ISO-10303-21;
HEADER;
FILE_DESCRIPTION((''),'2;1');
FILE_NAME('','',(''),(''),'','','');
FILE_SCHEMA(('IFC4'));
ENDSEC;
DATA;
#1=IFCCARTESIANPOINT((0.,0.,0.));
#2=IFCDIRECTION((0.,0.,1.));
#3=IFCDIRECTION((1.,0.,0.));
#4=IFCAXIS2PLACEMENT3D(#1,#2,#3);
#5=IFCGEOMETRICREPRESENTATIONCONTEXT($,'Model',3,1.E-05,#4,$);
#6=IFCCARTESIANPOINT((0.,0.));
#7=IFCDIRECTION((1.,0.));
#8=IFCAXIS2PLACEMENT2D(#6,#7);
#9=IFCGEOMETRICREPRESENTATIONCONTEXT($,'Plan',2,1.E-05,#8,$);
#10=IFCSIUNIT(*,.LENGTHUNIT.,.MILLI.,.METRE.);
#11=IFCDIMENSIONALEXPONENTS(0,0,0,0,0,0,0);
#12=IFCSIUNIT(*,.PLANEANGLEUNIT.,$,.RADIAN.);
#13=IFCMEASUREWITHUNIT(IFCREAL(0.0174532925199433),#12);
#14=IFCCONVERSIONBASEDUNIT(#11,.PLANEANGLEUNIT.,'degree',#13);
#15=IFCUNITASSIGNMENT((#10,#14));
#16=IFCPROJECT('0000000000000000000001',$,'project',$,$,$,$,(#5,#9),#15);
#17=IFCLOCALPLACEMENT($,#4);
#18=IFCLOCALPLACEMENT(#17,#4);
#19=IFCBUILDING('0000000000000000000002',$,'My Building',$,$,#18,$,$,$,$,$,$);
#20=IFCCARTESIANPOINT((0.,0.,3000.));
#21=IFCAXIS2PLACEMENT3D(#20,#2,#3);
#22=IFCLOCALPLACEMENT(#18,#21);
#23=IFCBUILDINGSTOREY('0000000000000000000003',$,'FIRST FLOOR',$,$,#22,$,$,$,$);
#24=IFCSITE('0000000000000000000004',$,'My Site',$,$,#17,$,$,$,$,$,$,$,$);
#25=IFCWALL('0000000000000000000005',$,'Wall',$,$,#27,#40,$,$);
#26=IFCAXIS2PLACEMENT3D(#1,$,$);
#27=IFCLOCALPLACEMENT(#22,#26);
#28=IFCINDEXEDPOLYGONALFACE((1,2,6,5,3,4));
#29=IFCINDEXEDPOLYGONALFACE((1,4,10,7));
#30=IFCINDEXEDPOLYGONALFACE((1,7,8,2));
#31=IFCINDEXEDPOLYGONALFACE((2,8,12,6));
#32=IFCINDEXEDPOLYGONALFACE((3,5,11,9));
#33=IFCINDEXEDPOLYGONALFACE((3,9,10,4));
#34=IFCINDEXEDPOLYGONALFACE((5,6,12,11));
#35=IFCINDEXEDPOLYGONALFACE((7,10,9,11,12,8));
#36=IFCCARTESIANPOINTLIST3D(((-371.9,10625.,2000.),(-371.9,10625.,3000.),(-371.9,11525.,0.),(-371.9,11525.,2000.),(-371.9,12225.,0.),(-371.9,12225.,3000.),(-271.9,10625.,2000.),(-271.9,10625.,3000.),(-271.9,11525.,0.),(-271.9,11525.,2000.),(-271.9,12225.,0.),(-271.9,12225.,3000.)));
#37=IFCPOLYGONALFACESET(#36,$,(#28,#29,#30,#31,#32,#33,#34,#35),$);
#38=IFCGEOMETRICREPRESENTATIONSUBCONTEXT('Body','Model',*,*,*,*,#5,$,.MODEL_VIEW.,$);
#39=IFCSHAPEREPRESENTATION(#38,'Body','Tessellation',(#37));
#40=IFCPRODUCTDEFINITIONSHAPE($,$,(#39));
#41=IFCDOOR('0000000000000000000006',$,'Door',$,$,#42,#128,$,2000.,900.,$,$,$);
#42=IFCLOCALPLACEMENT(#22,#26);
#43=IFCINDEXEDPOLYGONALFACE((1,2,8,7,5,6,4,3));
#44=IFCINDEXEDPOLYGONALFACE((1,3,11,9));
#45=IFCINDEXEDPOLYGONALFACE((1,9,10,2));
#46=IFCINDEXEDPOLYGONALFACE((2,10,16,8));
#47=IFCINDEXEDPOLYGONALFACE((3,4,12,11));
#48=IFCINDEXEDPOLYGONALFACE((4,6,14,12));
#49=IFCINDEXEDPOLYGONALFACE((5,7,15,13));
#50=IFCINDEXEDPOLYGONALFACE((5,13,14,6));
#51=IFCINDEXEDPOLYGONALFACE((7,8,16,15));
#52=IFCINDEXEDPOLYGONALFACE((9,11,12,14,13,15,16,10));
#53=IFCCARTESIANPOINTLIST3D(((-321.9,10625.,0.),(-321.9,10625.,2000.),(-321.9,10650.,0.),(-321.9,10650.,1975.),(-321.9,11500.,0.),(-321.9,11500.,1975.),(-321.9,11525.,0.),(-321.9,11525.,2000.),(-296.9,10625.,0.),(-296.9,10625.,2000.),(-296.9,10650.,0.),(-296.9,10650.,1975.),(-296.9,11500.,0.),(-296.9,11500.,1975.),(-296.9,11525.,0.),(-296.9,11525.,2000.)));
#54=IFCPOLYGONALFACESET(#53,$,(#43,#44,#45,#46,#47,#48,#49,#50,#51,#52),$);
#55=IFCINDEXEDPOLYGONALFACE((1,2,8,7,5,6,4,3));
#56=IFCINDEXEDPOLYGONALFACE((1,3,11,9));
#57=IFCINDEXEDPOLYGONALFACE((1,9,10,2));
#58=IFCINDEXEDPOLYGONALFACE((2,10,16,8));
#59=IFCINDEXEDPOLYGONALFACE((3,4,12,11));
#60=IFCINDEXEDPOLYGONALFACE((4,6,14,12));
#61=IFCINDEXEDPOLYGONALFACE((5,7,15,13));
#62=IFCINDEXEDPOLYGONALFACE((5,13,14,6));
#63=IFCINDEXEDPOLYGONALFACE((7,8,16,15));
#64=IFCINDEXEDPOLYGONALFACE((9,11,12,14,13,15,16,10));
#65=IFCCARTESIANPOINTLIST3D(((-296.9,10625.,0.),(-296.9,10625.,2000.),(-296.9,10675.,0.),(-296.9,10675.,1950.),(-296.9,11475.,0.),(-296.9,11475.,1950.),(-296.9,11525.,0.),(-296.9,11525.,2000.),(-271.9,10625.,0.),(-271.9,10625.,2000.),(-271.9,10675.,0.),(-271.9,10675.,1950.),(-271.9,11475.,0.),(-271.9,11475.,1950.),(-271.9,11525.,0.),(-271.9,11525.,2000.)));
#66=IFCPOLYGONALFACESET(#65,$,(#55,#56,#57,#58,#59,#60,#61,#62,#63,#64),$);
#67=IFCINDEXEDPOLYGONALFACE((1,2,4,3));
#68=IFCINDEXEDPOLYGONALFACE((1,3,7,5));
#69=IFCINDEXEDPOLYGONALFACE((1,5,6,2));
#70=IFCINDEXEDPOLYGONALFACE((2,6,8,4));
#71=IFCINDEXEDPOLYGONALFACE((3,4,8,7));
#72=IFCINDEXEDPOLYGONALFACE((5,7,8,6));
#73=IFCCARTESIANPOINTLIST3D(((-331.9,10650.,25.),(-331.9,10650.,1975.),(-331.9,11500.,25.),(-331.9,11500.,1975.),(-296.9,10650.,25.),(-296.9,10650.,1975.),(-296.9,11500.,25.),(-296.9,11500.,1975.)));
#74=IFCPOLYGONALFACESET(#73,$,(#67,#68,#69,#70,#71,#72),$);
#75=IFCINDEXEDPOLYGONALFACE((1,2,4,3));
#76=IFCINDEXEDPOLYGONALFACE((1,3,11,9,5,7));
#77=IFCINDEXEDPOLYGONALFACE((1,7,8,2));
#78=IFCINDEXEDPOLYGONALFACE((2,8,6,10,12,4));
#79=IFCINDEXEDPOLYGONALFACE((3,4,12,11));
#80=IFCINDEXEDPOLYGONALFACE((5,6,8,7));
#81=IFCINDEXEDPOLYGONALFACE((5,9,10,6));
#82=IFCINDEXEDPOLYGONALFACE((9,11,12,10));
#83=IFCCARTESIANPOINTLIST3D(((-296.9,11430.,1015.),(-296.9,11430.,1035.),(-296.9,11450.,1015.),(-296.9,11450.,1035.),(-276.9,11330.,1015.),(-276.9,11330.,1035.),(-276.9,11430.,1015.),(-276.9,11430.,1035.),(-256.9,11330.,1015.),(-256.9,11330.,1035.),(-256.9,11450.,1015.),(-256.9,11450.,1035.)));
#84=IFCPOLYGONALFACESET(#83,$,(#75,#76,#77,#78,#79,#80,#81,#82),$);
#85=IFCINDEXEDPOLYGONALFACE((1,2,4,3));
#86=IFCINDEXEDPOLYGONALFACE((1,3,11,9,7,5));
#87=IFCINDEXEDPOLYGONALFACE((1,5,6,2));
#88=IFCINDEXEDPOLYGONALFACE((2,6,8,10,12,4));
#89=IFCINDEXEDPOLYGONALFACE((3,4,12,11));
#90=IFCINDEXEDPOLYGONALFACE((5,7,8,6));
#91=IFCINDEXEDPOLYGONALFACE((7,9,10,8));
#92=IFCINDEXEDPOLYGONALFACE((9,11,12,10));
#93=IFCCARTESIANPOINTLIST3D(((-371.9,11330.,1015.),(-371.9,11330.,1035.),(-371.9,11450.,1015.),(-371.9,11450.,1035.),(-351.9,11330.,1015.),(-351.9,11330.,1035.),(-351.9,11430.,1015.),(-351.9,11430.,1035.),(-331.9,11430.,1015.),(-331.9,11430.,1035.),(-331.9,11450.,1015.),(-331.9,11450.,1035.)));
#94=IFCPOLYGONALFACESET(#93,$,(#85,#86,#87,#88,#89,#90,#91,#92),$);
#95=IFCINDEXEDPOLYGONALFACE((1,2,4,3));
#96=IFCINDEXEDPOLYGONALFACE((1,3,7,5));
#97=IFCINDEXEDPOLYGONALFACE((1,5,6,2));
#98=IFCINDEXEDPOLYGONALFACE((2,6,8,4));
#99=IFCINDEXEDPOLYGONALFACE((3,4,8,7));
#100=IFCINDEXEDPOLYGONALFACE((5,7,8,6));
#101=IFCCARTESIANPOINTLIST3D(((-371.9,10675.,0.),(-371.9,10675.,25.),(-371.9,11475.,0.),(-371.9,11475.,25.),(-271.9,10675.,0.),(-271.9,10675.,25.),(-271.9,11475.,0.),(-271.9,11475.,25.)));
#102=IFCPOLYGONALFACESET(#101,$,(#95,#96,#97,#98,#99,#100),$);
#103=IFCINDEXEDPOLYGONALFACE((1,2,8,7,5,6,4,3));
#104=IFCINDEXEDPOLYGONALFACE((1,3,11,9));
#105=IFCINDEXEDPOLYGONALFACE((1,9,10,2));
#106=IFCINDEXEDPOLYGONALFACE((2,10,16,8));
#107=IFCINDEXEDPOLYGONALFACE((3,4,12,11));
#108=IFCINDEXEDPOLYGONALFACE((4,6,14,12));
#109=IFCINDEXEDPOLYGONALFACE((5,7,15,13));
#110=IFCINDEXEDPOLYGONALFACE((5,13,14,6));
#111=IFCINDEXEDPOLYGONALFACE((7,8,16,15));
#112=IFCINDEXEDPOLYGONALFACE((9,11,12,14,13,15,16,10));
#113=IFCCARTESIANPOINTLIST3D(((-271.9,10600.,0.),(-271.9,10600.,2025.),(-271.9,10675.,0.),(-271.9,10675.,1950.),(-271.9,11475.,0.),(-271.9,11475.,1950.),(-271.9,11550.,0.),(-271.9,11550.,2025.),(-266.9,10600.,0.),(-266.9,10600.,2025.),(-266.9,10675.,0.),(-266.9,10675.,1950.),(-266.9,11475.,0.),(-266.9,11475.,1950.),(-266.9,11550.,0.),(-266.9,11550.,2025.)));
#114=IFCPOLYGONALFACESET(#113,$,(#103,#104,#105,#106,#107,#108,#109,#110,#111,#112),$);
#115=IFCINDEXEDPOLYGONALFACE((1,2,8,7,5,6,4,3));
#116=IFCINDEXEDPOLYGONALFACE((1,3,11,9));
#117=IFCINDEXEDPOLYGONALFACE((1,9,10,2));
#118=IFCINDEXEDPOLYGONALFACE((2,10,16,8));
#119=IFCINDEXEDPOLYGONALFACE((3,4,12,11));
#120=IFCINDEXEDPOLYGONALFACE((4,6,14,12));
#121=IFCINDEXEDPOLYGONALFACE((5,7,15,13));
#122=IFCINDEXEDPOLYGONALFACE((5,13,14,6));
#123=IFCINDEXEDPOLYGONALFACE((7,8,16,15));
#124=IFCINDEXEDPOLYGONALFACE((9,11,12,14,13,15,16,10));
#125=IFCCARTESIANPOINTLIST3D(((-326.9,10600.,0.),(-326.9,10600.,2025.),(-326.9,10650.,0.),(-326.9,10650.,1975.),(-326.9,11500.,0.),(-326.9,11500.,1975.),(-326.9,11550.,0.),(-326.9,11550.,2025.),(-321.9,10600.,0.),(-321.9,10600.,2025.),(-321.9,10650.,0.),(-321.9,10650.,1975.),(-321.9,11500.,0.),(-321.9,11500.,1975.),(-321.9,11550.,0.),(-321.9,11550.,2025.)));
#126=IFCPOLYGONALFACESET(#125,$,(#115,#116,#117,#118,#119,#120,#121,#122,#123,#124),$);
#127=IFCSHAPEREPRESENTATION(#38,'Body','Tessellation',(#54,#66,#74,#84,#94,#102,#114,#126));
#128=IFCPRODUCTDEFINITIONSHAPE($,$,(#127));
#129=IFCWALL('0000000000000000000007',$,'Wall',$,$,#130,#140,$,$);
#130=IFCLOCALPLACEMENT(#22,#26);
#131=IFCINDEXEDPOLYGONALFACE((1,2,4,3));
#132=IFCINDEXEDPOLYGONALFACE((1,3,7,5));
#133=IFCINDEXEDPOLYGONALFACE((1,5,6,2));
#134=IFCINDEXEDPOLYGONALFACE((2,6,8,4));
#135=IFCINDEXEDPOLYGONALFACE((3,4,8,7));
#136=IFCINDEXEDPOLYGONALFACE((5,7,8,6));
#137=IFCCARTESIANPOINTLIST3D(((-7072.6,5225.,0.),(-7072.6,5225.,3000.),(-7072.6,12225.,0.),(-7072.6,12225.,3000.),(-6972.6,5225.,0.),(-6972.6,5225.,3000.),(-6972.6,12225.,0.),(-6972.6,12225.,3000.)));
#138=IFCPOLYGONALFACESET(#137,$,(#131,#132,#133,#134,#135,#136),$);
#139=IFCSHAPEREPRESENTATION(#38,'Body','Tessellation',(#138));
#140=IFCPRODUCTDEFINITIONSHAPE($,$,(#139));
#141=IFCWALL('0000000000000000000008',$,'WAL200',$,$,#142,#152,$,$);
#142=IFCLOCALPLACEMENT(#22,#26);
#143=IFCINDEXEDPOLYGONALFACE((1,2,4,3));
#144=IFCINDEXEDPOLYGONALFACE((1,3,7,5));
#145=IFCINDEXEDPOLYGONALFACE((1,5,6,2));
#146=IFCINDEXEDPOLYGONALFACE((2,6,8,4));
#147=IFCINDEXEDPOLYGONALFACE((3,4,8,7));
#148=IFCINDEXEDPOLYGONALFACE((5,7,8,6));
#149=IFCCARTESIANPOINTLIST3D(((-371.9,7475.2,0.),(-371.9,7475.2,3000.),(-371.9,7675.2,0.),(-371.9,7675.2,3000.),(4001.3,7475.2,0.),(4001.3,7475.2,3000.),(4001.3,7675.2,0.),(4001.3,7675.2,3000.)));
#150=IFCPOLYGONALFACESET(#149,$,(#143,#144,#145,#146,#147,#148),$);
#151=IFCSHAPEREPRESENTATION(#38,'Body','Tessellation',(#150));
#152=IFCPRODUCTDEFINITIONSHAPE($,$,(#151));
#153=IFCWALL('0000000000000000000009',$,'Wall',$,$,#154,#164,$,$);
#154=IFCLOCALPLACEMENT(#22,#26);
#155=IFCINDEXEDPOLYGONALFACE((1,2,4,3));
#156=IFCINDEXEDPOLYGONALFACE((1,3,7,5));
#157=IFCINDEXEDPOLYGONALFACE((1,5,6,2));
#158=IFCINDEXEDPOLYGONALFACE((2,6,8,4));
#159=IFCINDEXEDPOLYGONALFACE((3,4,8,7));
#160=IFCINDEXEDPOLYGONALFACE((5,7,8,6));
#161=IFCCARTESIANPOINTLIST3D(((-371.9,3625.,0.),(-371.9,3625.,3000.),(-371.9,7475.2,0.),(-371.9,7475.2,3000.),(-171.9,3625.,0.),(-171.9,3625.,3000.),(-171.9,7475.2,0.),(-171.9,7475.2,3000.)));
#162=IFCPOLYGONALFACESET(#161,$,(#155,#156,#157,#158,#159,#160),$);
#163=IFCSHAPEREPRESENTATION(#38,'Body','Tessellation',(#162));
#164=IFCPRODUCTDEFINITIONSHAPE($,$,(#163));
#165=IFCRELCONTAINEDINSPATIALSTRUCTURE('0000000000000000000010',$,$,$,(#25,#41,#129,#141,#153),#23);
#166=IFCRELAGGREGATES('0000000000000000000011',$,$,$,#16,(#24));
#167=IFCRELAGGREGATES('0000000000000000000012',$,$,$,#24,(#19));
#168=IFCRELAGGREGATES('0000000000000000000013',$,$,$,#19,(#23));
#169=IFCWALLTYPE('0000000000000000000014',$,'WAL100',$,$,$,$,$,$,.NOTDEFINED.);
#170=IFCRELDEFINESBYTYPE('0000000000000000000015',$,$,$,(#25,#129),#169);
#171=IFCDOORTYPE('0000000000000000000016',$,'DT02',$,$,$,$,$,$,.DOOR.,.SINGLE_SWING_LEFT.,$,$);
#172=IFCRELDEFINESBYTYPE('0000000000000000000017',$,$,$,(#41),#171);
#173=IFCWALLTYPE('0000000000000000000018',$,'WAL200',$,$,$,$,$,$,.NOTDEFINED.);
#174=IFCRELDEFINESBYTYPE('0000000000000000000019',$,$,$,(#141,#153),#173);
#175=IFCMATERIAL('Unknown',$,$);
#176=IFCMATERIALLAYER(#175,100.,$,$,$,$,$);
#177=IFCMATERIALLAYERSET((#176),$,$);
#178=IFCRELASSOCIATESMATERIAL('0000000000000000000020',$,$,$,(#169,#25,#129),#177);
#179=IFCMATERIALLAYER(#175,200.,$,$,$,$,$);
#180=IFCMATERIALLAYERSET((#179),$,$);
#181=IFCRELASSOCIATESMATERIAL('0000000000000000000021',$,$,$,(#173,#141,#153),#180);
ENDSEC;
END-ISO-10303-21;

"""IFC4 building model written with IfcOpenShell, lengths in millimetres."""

from ifc_helpers import new_model, entity, si_unit, converted_unit, frame, origin_with_axes, origin_2d_with_axis, place, context, subcontext, project, spatial, line, indexed_curve, outline, extrude, shape, source, transform, mapped, material, layer, layer_set, layer_usage, type_object, type_shapes, element, fill, save


model = new_model("IFC4")

# Units and contexts
model_context = context("Model", 3, precision=1e-05, world=origin_with_axes())
plan_context = context("Plan", 2, precision=1e-05, world=origin_2d_with_axis())
body_context_1 = subcontext(model_context, "Body", "Model", "MODEL_VIEW")
body_context_2 = subcontext(plan_context, "Body", "Plan", "PLAN_VIEW")
ifc_project = project(units=[si_unit("LENGTHUNIT", "METRE", prefix="MILLI"), converted_unit("PLANEANGLEUNIT", "degree", entity("IfcReal", 0.0174532925199433), si_unit("PLANEANGLEUNIT", "RADIAN"), dimensions=[0, 0, 0, 0, 0, 0, 0])], contexts=[model_context, plan_context])

# Site, building, storey
site_placement = place(None, origin_with_axes())
site = spatial("IfcSite", under=ifc_project, at=site_placement, Name="My Site")
building_placement = place(site_placement, origin_with_axes())
building = spatial("IfcBuilding", under=site, at=building_placement, Name="My Building")
storey_placement = place(building_placement, frame((0.0, 0.0, 3000.0), z_axis=(0.0, 0.0, 1.0), x_axis=(1.0, 0.0, 0.0)))
storey = spatial("IfcBuildingStorey", under=building, at=storey_placement, Name="FIRST FLOOR")

# Shared definitions
ifc_material = material(Name="Unknown")

# Shared definitions
ifc_layer_1 = layer(ifc_material, 100.0)
ifc_layer_set_1 = layer_set([ifc_layer_1])
wall_type_1 = type_object("IfcWallType", Name="WAL100", PredefinedType="NOTDEFINED", material=ifc_layer_set_1)
wall_1_placement = place(storey_placement, frame((-271.9, 7675.2, 0.0), z_axis=(0.0, 0.0, 1.0), x_axis=(0.0, 1.0, 0.0)))

# Wall, opening, door
ifc_layer_usage_1 = layer_usage(ifc_layer_set_1, "AXIS2", "POSITIVE", 0.0)
wall_2_placement = place(storey_placement, frame((-271.9, 10625.0, 0.0), z_axis=(0.0, 0.0, 1.0), x_axis=(0.0, 1.0, 0.0)))
wall_2 = element("IfcWall", 1, at=wall_2_placement, inside=storey, type_object=wall_type_1, material=ifc_layer_usage_1, Name="Wall", context=body_context_1, shape_type="SweptSolid", body=[
    extrude(outline(indexed_curve([(0.0, 0.0), (0.0, 100.0), (1600.0, 100.0), (1600.0, 0.0), (0.0, 0.0)], self_intersect=False)), origin_with_axes(), (0.0, 0.0, 1.0), 3000.0),
])
shared_shape_1 = source(origin_with_axes(), body_context_1, "Body", "SweptSolid", [
    extrude(outline(indexed_curve([(0.0, 0.0), (900.0, 0.0), (900.0, 2000.0), (0.0, 2000.0)], segments=[line(1, 2), line(2, 3), line(3, 4), line(4, 1)])), frame((0.0, -100.0, 0.0), z_axis=(0.0, -1.0, 0.0), x_axis=(1.0, 0.0, 0.0)), (0.0, 0.0, -1.0), 300.0),
])
opening_1_placement = place(wall_2_placement, frame((0.0, 0.0, 0.0), z_axis=(0.0, 0.0, 1.0), x_axis=(1.0, 0.0, 0.0)))
opening_1 = element("IfcOpeningElement", 2, at=opening_1_placement, cuts=wall_2, PredefinedType="OPENING", context=body_context_1, shape_type="MappedRepresentation", body=[
    mapped(shared_shape_1, transform((0.0, 0.0, 0.0), x_axis=(1.0, 0.0, 0.0), y_axis=(0.0, 1.0, 0.0), z_axis=(0.0, 0.0, 1.0), scale=1.0)),
])
door_type = type_object("IfcDoorType", Name="DT02", OperationType="SINGLE_SWING_LEFT", PredefinedType="DOOR")
shared_shape_2 = source(origin_with_axes(), body_context_1, "Body", "SweptSolid", [
    extrude(outline(indexed_curve([(0.0, 0.0), (0.0, 2000.0), (900.0, 2000.0), (900.0, 0.0), (875.0, 0.0), (875.0, 1975.0), (25.0, 1975.0), (25.0, 0.0)], segments=[line(1, 2), line(2, 3), line(3, 4), line(4, 5), line(5, 6), line(6, 7), line(7, 8), line(8, 1)])), frame((0.0, 25.0, 0.0), z_axis=(0.0, -1.0, 0.0), x_axis=(1.0, 0.0, 0.0)), (0.0, 0.0, -1.0), 25.0),
    extrude(outline(indexed_curve([(0.0, 0.0), (0.0, 2000.0), (900.0, 2000.0), (900.0, 0.0), (850.0, 0.0), (850.0, 1950.0), (50.0, 1950.0), (50.0, 0.0)], segments=[line(1, 2), line(2, 3), line(3, 4), line(4, 5), line(5, 6), line(6, 7), line(7, 8), line(8, 1)])), frame((0.0, 0.0, 0.0), z_axis=(0.0, -1.0, 0.0), x_axis=(1.0, 0.0, 0.0)), (0.0, 0.0, -1.0), 25.0),
    extrude(outline(indexed_curve([(0.0, 0.0), (850.0, 0.0), (850.0, 35.0), (0.0, 35.0)], segments=[line(1, 2), line(2, 3), line(3, 4), line(4, 1)])), frame((25.0, 25.0, 25.0), z_axis=(0.0, 0.0, 1.0), x_axis=(1.0, 0.0, 0.0)), (0.0, 0.0, 1.0), 1950.0),
    extrude(outline(indexed_curve([(0.0, 0.0), (0.0, -40.0), (-120.0, -40.0), (-120.0, -20.0), (-20.0, -20.0), (-20.0, 0.0)], segments=[line(1, 2), line(2, 3), line(3, 4), line(4, 5), line(5, 6), line(6, 1)])), frame((825.0, 25.0, 1015.0), z_axis=(0.0, 0.0, 1.0), x_axis=(1.0, 0.0, 0.0)), (0.0, 0.0, 1.0), 20.0),
    extrude(outline(indexed_curve([(0.0, 0.0), (0.0, 40.0), (-120.0, 40.0), (-120.0, 20.0), (-20.0, 20.0), (-20.0, 0.0)], segments=[line(1, 2), line(2, 3), line(3, 4), line(4, 5), line(5, 6), line(6, 1)])), frame((825.0, 60.0, 1015.0), z_axis=(0.0, 0.0, 1.0), x_axis=(1.0, 0.0, 0.0)), (0.0, 0.0, 1.0), 20.0),
    extrude(outline(indexed_curve([(0.0, 0.0), (800.0, 0.0), (800.0, 100.0), (0.0, 100.0)], segments=[line(1, 2), line(2, 3), line(3, 4), line(4, 1)])), frame((50.0, 0.0, 0.0), z_axis=(0.0, 0.0, 1.0), x_axis=(1.0, 0.0, 0.0)), (0.0, 0.0, 1.0), 25.0),
    extrude(outline(indexed_curve([(0.0, 0.0), (0.0, 2025.0), (950.0, 2025.0), (950.0, 0.0), (875.0, 0.0), (875.0, 1950.0), (75.0, 1950.0), (75.0, 0.0)], segments=[line(1, 2), line(2, 3), line(3, 4), line(4, 5), line(5, 6), line(6, 7), line(7, 8), line(8, 1)])), frame((-25.0, -5.0, 0.0), z_axis=(0.0, -1.0, 0.0), x_axis=(1.0, 0.0, 0.0)), (0.0, 0.0, -1.0), 5.0),
    extrude(outline(indexed_curve([(0.0, 0.0), (0.0, 2025.0), (950.0, 2025.0), (950.0, 0.0), (900.0, 0.0), (900.0, 1975.0), (50.0, 1975.0), (50.0, 0.0)], segments=[line(1, 2), line(2, 3), line(3, 4), line(4, 5), line(5, 6), line(6, 7), line(7, 8), line(8, 1)])), frame((-25.0, 50.0, 0.0), z_axis=(0.0, -1.0, 0.0), x_axis=(1.0, 0.0, 0.0)), (0.0, 0.0, -1.0), 5.0),
])
shared_shape_3 = source(origin_with_axes(), body_context_2, "Body", "Curve2D", [
    entity("IfcIndexedPolyCurve", entity("IfcCartesianPointList2D", [[0.0, 0.0], [0.0, 50.0], [25.0, 50.0], [25.0, 25.0], [50.0, 25.0], [50.0, 0.0]]), [entity("IfcLineIndex", [1, 2]), entity("IfcLineIndex", [2, 3]), entity("IfcLineIndex", [3, 4]), entity("IfcLineIndex", [4, 5]), entity("IfcLineIndex", [5, 6]), entity("IfcLineIndex", [6, 1])]),
    entity("IfcIndexedPolyCurve", entity("IfcCartesianPointList2D", [[900.0, 0.0], [900.0, 50.0], [875.0, 50.0], [875.0, 25.0], [850.0, 25.0], [850.0, 0.0]]), [entity("IfcLineIndex", [1, 2]), entity("IfcLineIndex", [2, 3]), entity("IfcLineIndex", [3, 4]), entity("IfcLineIndex", [4, 5]), entity("IfcLineIndex", [5, 6]), entity("IfcLineIndex", [6, 1])]),
    entity("IfcTrimmedCurve", entity("IfcEllipse", entity("IfcAxis2Placement2D", entity("IfcCartesianPoint", [60.0, 50.0]), entity("IfcDirection", [1.0, 0.0])), 815.0, 850.0), [entity("IfcCartesianPoint", [875.0, 50.0])], [entity("IfcCartesianPoint", [60.0, 900.0])], True, "CARTESIAN"),
    entity("IfcIndexedPolyCurve", entity("IfcCartesianPointList2D", [[25.0, 50.0], [60.0, 50.0], [60.0, 900.0], [25.0, 900.0]]), [entity("IfcLineIndex", [1, 2]), entity("IfcLineIndex", [2, 3]), entity("IfcLineIndex", [3, 4]), entity("IfcLineIndex", [4, 1])]),
])
type_shapes(door_type, [shared_shape_2, shared_shape_3])
placement = place(wall_1_placement, frame((2949.8, 0.0, 0.0), z_axis=(0.0, 0.0, 1.0), x_axis=(1.0, 0.0, 0.0)))
door_1_placement = place(placement, frame((0.0, 0.0, 0.0), z_axis=(0.0, 0.0, 1.0), x_axis=(1.0, 0.0, 0.0)))
door_1 = element("IfcDoor", 3, at=door_1_placement, inside=storey, type_object=door_type, Name="Door", OverallHeight=2000.0, OverallWidth=900.0, shapes=[
    shape(body_context_1, "Body", "MappedRepresentation", [mapped(shared_shape_2, transform((0.0, 0.0, 0.0), x_axis=(1.0, 0.0, 0.0), y_axis=(0.0, 1.0, 0.0), z_axis=(0.0, 0.0, 1.0), scale=1.0))]),
    shape(body_context_2, "Body", "MappedRepresentation", [mapped(shared_shape_3, transform((0.0, 0.0, 0.0), x_axis=(1.0, 0.0, 0.0), y_axis=(0.0, 1.0, 0.0), z_axis=(0.0, 0.0, 1.0), scale=1.0))]),
])
fill(opening_1, door_1)

# Walls
ifc_layer_usage_2 = layer_usage(ifc_layer_set_1, "AXIS2", "POSITIVE", 0.0)
wall_3_placement = place(storey_placement, frame((-6972.6, 5225.0, 0.0), z_axis=(0.0, 0.0, 1.0), x_axis=(0.000001, 1.0, 0.0)))
element("IfcWall", 4, at=wall_3_placement, inside=storey, type_object=wall_type_1, material=ifc_layer_usage_2, Name="Wall", context=body_context_1, shape_type="SweptSolid", body=[
    extrude(outline(indexed_curve([(0.0, 0.0), (0.0, 100.0), (7000.0, 100.0), (7000.0, 0.0), (0.0, 0.0)], self_intersect=False)), origin_with_axes(), (0.0, 0.0, 1.0), 3000.0),
])
ifc_layer_2 = layer(ifc_material, 200.0)
ifc_layer_set_2 = layer_set([ifc_layer_2])
ifc_layer_usage_3 = layer_usage(ifc_layer_set_2, "AXIS2", "POSITIVE", 0.0)
wall_type_2 = type_object("IfcWallType", Name="WAL200", PredefinedType="NOTDEFINED", material=ifc_layer_set_2)
wall_4_placement = place(storey_placement, frame((4001.3, 7675.2, 0.0), z_axis=(0.0, 0.0, 1.0), x_axis=(-1.0, 0.0, 0.0)))
element("IfcWall", 5, at=wall_4_placement, inside=storey, type_object=wall_type_2, material=ifc_layer_usage_3, Name="WAL200", context=body_context_1, shape_type="SweptSolid", body=[
    extrude(outline(indexed_curve([(0.0, 0.0), (0.0, 200.0), (4373.2, 200.0), (4373.2, 0.0), (0.0, 0.0)], self_intersect=False)), origin_with_axes(), (0.0, 0.0, 1.0), 3000.0),
])
ifc_layer_usage_4 = layer_usage(ifc_layer_set_2, "AXIS2", "POSITIVE", 0.0)
wall_5_placement = place(storey_placement, frame((-171.9, 3625.0, 0.0), z_axis=(0.0, 0.0, 1.0), x_axis=(0.0, 1.0, 0.0)))
element("IfcWall", 6, at=wall_5_placement, inside=storey, type_object=wall_type_2, material=ifc_layer_usage_4, Name="Wall", context=body_context_1, shape_type="SweptSolid", body=[
    extrude(outline(indexed_curve([(0.0, 0.0), (0.0, 200.0), (3850.2, 200.0), (3850.2, 0.0), (0.0, 0.0)], self_intersect=False)), origin_with_axes(), (0.0, 0.0, 1.0), 3000.0),
])

save(model, "model.ifc")
